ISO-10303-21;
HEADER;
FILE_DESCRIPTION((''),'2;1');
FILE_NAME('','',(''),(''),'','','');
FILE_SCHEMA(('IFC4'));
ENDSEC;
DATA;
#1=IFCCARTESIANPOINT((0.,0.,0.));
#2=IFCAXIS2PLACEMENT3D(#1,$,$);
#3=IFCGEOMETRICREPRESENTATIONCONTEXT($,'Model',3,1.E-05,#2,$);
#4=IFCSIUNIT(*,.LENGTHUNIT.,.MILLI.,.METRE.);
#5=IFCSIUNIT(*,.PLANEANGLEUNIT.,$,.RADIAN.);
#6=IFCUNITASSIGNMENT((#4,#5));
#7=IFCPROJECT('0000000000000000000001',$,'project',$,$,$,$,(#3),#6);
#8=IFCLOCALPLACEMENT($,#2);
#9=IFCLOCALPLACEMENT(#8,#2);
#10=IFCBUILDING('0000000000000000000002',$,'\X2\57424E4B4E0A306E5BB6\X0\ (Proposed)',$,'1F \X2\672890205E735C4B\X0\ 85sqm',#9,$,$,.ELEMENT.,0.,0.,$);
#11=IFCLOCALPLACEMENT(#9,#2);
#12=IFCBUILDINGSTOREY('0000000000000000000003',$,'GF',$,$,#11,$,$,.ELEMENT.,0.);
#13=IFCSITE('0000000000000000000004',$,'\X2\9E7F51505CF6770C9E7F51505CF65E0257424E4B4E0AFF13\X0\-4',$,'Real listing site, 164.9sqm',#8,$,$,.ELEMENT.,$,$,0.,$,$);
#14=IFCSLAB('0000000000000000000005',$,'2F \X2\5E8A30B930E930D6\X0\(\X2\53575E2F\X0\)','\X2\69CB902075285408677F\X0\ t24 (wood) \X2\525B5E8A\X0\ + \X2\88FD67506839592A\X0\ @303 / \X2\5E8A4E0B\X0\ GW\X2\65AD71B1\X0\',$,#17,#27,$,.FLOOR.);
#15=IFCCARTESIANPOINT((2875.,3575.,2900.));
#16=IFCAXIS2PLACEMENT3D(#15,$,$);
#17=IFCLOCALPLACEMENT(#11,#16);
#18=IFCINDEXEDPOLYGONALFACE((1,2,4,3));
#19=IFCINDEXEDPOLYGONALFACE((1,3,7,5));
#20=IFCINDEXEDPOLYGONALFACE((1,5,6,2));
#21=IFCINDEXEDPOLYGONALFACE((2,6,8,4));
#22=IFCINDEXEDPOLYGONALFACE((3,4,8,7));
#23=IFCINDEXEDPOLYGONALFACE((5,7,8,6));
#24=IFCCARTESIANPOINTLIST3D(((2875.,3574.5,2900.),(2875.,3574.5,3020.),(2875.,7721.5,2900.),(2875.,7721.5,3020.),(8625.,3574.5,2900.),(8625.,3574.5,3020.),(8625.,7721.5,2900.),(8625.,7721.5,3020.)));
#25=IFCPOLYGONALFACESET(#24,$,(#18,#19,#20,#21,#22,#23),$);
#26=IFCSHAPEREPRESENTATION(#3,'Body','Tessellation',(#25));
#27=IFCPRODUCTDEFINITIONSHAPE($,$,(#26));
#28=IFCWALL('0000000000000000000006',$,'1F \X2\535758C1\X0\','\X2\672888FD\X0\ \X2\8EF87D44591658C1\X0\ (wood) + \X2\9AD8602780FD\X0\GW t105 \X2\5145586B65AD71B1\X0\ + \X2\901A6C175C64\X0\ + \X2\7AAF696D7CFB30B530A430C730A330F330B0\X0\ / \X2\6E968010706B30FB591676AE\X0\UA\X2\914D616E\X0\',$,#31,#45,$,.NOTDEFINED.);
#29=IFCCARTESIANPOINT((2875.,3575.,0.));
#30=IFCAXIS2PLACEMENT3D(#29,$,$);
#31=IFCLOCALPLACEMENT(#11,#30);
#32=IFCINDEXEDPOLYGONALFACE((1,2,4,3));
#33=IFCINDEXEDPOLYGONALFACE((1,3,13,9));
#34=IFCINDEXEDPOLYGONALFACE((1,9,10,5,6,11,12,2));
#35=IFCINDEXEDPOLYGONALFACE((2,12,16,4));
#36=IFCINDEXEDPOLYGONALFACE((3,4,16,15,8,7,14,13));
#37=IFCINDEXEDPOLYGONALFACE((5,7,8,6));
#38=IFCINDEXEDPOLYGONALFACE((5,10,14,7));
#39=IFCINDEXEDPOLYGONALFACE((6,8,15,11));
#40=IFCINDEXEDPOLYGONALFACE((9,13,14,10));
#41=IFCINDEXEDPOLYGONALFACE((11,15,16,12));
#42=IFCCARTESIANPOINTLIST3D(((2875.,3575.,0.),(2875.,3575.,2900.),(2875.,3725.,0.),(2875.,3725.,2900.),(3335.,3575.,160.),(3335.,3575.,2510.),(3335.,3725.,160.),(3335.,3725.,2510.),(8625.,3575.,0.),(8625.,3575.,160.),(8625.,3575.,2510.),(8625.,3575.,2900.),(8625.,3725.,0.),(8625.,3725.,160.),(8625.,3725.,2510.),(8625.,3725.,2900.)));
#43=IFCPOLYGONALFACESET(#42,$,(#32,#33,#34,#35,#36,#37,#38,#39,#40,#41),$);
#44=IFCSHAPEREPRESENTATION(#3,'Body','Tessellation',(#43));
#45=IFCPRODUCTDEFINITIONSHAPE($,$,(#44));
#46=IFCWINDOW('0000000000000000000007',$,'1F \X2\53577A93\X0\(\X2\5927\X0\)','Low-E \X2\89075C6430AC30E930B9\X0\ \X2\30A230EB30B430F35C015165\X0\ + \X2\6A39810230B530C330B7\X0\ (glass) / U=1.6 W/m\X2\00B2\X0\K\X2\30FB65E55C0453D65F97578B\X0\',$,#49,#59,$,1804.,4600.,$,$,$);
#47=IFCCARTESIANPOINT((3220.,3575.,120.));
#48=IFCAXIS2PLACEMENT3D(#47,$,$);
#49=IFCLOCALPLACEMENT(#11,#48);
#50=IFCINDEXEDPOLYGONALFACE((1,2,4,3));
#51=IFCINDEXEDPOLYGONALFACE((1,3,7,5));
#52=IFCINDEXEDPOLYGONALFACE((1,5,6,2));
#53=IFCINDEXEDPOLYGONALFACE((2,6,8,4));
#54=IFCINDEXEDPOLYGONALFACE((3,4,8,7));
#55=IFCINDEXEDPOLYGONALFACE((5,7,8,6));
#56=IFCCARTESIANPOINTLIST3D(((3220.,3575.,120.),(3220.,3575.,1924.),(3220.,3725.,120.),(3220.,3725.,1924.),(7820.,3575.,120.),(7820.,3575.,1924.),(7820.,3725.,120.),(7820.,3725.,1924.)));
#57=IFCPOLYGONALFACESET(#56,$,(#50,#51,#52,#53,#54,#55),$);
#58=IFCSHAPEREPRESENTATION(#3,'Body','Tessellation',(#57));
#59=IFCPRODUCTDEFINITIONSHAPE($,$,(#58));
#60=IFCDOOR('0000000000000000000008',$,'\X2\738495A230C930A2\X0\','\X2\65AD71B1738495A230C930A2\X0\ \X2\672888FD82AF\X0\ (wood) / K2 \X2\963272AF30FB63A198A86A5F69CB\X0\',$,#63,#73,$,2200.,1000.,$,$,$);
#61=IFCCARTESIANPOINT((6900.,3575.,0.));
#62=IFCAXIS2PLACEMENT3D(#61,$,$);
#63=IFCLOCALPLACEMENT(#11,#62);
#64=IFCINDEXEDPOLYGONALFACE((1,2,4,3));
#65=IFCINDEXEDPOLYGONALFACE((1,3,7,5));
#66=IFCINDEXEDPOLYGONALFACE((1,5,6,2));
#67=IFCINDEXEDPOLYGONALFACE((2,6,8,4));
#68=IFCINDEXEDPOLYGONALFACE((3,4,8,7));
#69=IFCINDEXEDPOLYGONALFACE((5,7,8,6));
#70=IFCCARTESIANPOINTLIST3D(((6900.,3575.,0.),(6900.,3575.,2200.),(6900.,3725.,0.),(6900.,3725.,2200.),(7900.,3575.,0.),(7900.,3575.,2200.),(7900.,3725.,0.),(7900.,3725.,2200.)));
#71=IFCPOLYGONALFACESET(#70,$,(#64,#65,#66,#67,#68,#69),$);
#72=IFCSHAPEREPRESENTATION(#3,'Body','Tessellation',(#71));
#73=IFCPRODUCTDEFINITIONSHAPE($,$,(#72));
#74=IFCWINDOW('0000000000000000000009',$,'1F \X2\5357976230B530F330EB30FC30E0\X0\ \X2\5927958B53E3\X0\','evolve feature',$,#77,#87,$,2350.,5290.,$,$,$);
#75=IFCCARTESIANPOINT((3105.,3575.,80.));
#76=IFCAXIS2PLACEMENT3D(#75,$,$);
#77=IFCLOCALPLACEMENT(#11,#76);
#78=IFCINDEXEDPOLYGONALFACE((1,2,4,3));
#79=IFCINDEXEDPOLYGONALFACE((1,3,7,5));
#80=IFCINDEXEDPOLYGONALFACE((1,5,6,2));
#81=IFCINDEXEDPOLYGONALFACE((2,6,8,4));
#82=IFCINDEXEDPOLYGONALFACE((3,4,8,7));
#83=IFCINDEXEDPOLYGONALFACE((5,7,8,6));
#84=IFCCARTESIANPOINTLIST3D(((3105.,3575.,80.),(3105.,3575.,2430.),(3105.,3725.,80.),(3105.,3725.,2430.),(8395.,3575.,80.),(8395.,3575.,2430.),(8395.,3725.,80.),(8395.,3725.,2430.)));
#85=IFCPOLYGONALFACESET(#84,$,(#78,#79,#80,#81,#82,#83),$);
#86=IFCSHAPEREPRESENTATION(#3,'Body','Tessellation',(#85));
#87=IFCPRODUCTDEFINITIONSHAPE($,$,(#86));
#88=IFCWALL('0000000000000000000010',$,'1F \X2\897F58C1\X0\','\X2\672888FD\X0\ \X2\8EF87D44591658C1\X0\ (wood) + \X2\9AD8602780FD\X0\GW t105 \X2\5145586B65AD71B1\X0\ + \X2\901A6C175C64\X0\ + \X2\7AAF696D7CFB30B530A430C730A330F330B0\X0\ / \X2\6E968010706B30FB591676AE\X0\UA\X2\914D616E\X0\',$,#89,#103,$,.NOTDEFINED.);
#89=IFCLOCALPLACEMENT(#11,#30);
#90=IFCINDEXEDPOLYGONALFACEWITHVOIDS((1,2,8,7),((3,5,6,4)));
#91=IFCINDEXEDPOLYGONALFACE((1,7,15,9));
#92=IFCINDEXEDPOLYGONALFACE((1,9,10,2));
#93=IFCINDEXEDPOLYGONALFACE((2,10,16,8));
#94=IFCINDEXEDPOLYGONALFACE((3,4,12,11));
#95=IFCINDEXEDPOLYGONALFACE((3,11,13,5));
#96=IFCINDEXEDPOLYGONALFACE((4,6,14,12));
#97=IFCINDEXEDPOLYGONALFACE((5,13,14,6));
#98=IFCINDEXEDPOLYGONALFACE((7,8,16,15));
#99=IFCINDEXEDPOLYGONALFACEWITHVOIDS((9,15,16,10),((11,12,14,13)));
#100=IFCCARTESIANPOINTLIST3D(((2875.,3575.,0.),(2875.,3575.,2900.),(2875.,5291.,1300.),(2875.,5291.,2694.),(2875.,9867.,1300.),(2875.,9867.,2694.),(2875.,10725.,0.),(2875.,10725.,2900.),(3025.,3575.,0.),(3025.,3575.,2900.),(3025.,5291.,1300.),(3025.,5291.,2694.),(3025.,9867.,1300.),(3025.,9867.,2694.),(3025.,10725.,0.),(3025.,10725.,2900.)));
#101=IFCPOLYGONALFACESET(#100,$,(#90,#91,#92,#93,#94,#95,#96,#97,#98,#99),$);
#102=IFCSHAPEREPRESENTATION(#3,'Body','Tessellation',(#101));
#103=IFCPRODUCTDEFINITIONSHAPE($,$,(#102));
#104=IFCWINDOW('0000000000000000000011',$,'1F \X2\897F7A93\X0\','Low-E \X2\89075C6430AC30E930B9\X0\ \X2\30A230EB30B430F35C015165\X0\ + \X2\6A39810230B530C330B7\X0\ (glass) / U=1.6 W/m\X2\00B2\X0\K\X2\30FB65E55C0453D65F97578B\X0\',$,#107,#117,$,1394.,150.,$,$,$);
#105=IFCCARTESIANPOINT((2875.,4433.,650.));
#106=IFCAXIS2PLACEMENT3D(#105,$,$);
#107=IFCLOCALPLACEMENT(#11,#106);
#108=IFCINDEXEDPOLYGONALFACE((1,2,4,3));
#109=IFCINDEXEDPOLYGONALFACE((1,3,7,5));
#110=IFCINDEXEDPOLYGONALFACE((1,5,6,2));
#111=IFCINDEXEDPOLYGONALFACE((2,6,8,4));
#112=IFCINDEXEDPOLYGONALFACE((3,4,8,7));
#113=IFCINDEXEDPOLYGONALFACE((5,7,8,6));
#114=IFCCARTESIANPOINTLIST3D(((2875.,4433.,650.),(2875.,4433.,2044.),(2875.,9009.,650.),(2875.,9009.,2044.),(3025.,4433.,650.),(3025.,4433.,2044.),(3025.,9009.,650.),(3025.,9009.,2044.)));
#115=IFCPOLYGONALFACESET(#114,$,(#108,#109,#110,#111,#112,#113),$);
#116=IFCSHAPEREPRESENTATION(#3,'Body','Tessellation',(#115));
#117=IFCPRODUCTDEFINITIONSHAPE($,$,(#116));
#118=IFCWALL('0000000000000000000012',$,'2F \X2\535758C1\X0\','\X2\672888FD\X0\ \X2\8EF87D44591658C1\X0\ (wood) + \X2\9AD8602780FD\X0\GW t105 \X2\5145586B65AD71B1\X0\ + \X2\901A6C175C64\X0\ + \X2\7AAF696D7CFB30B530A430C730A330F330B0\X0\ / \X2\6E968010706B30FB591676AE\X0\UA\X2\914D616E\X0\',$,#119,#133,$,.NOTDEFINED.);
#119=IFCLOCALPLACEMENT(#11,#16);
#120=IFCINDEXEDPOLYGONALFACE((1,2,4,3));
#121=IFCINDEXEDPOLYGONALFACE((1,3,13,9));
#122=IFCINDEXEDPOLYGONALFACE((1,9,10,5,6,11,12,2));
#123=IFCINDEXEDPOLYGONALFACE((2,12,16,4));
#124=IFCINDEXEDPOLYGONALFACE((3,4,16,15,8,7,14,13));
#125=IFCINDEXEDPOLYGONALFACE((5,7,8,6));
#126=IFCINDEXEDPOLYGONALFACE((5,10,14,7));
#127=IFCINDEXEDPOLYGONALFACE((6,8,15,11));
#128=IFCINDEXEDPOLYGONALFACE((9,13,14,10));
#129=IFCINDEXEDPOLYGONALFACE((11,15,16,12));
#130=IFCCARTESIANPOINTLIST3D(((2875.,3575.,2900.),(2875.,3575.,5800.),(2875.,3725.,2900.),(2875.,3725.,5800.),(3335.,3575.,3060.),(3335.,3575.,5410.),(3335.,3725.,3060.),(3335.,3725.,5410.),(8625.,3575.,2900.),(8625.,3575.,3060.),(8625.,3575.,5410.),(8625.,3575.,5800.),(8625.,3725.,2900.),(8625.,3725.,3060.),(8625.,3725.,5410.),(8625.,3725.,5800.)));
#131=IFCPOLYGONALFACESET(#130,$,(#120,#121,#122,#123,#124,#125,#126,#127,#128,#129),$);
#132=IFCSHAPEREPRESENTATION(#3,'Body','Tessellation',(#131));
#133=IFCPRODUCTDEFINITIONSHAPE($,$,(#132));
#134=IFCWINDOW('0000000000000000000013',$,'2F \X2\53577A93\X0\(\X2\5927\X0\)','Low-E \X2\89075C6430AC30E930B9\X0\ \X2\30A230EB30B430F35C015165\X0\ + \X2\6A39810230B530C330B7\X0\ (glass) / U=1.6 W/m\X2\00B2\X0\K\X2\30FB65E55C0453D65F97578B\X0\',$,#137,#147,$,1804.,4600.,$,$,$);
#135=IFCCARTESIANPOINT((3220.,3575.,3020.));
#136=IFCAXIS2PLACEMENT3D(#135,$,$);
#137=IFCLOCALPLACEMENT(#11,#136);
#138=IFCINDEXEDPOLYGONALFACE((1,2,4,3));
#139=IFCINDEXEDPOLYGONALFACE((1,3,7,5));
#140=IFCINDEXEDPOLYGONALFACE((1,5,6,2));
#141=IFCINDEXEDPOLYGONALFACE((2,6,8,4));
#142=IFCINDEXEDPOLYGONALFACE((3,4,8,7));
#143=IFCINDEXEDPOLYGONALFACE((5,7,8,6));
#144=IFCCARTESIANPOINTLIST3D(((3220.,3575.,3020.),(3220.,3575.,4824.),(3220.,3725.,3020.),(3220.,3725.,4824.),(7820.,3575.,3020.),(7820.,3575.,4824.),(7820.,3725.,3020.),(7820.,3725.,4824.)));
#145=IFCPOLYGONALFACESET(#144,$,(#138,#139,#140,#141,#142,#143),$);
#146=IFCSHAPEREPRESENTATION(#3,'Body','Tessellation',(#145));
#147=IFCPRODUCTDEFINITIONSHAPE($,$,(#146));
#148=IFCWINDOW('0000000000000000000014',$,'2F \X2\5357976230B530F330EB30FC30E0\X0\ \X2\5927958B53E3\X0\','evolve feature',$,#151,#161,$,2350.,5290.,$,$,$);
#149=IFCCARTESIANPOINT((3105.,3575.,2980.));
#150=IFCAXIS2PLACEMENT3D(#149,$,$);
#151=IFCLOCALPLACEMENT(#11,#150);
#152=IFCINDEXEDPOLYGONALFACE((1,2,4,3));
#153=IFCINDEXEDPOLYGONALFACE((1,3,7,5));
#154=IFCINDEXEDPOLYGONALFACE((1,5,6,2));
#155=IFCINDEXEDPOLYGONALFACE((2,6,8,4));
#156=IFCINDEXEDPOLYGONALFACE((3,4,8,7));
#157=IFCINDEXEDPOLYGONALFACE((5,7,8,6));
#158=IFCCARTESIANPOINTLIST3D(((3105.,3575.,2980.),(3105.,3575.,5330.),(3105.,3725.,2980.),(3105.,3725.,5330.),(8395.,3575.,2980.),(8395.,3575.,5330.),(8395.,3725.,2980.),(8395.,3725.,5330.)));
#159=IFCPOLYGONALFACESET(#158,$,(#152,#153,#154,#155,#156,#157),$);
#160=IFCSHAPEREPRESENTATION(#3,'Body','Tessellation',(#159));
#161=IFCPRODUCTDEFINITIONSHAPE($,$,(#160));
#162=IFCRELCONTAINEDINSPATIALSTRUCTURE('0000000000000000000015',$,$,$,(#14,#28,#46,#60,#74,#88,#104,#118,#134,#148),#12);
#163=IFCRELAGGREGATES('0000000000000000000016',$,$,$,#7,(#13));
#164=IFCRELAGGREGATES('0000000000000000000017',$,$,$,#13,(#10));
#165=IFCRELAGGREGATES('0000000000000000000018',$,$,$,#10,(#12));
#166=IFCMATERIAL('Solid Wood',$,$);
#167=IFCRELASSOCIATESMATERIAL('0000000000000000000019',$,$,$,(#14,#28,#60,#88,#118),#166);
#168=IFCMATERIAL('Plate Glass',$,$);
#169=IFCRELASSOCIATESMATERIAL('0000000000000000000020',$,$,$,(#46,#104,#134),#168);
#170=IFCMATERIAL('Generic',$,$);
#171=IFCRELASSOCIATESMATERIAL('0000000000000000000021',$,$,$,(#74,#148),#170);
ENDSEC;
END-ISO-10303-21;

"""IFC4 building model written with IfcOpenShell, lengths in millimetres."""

from ifc_helpers import new_model, si_unit, frame, frame_2d, origin, place, context, project, spatial, rectangle, extrude, material, element, fill, save


model = new_model("IFC4")

# Units and contexts
model_context = context("Model", 3, precision=1e-05, world=origin())
ifc_project = project(units=[si_unit("LENGTHUNIT", "METRE", prefix="MILLI"), si_unit("PLANEANGLEUNIT", "RADIAN")], contexts=[model_context])

# Site, building, storey
site_placement = place(None, origin())
site = spatial("IfcSite", under=ifc_project, at=site_placement, Name="鹿児島県鹿児島市坂之上３-4", ObjectType="Real listing site, 164.9sqm", CompositionType="ELEMENT", RefElevation=0.0)
building_placement = place(site_placement, origin())
building = spatial("IfcBuilding", under=site, at=building_placement, Name="坂之上の家 (Proposed)", ObjectType="1F 木造平屋 85sqm", CompositionType="ELEMENT", ElevationOfRefHeight=0.0, ElevationOfTerrain=0.0)
storey_placement = place(building_placement, origin())
storey = spatial("IfcBuildingStorey", under=building, at=storey_placement, Name="GF", CompositionType="ELEMENT", Elevation=0.0)

# Slab
ifc_material_1 = material(Name="Solid Wood")
slab_1_placement = place(storey_placement, frame((2875.0, 3575.0, 2900.0)))
element("IfcSlab", 1, at=slab_1_placement, inside=storey, material=ifc_material_1, Name="2F 床スラブ(南帯)", Description="構造用合板 t24 (wood) 剛床 + 製材根太 @303 / 床下 GW断熱", PredefinedType="FLOOR", context=model_context, shape_type="SweptSolid", body=[
    extrude(rectangle(XDim=5750.0, YDim=4147.0, at=frame_2d((2875.0, 2073.0))), frame((2875.0, 3575.0, 2900.0)), (0.0, 0.0, 1.0), 120.0),
])
ifc_material_2 = material(Name="Generic")

# Wall, openings, windows, door
wall_1_placement = place(storey_placement, frame((2875.0, 3575.0, 0.0)))
wall_1 = element("IfcWall", 2, at=wall_1_placement, inside=storey, material=ifc_material_1, Name="1F 南壁", Description="木製 軸組外壁 (wood) + 高性能GW t105 充填断熱 + 通気層 + 窯業系サイディング / 準耐火・外皮UA配慮", PredefinedType="NOTDEFINED", context=model_context, shape_type="SweptSolid", body=[
    extrude(rectangle(XDim=5750.0, YDim=150.0, at=frame_2d((2875.0, 75.0))), frame((2875.0, 3575.0, 0.0)), (0.0, 0.0, 1.0), 2900.0),
])
opening_1_placement = place(storey_placement, frame((3220.0, 3575.0, 120.0)))
opening_1 = element("IfcOpeningElement", 3, at=opening_1_placement, cuts=wall_1, PredefinedType="NOTDEFINED", context=model_context, shape_type="SweptSolid", body=[
    extrude(rectangle(XDim=4600.0, YDim=150.0, at=frame_2d((2300.0, 75.0))), frame((3220.0, 3575.0, 120.0)), (0.0, 0.0, 1.0), 1804.0),
])
opening_2_placement = place(storey_placement, frame((6900.0, 3575.0, 0.0)))
opening_2 = element("IfcOpeningElement", 4, at=opening_2_placement, cuts=wall_1, PredefinedType="NOTDEFINED", context=model_context, shape_type="SweptSolid", body=[
    extrude(rectangle(XDim=1000.0, YDim=150.0, at=frame_2d((500.0, 75.0))), frame((6900.0, 3575.0, 0.0)), (0.0, 0.0, 1.0), 2200.0),
])
opening_3_placement = place(storey_placement, frame((3105.0, 3575.0, 80.0)))
opening_3 = element("IfcOpeningElement", 5, at=opening_3_placement, cuts=wall_1, PredefinedType="NOTDEFINED", context=model_context, shape_type="SweptSolid", body=[
    extrude(rectangle(XDim=5290.0, YDim=150.0, at=frame_2d((2645.0, 75.0))), frame((3105.0, 3575.0, 80.0)), (0.0, 0.0, 1.0), 2350.0),
])
ifc_material_3 = material(Name="Plate Glass")
window_1_placement = place(storey_placement, frame((3220.0, 3575.0, 120.0)))
window_1 = element("IfcWindow", 6, at=window_1_placement, inside=storey, material=ifc_material_3, Name="1F 南窓(大)", Description="Low-E 複層ガラス アルゴン封入 + 樹脂サッシ (glass) / U=1.6 W/m²K・日射取得型", OverallHeight=1804.0, OverallWidth=4600.0, context=model_context, shape_type="SweptSolid", body=[
    extrude(rectangle(XDim=4600.0, YDim=150.0, at=frame_2d((2300.0, 75.0))), frame((3220.0, 3575.0, 120.0)), (0.0, 0.0, 1.0), 1804.0),
])
fill(opening_1, window_1)
door_placement = place(storey_placement, frame((6900.0, 3575.0, 0.0)))
door = element("IfcDoor", 7, at=door_placement, inside=storey, material=ifc_material_1, Name="玄関ドア", Description="断熱玄関ドア 木製芯 (wood) / K2 防犯・採風機構", OverallHeight=2200.0, OverallWidth=1000.0, context=model_context, shape_type="SweptSolid", body=[
    extrude(rectangle(XDim=1000.0, YDim=150.0, at=frame_2d((500.0, 75.0))), frame((6900.0, 3575.0, 0.0)), (0.0, 0.0, 1.0), 2200.0),
])
fill(opening_2, door)
window_2_placement = place(storey_placement, frame((3105.0, 3575.0, 80.0)))
window_2 = element("IfcWindow", 8, at=window_2_placement, inside=storey, material=ifc_material_2, Name="1F 南面サンルーム 大開口", Description="evolve feature", OverallHeight=2350.0, OverallWidth=5290.0, context=model_context, shape_type="SweptSolid", body=[
    extrude(rectangle(XDim=5290.0, YDim=150.0, at=frame_2d((2645.0, 75.0))), frame((3105.0, 3575.0, 80.0)), (0.0, 0.0, 1.0), 2350.0),
])
fill(opening_3, window_2)

# Wall, opening, window
wall_2_placement = place(storey_placement, frame((2875.0, 3575.0, 0.0)))
wall_2 = element("IfcWall", 9, at=wall_2_placement, inside=storey, material=ifc_material_1, Name="1F 西壁", Description="木製 軸組外壁 (wood) + 高性能GW t105 充填断熱 + 通気層 + 窯業系サイディング / 準耐火・外皮UA配慮", PredefinedType="NOTDEFINED", context=model_context, shape_type="SweptSolid", body=[
    extrude(rectangle(XDim=150.0, YDim=7150.0, at=frame_2d((75.0, 3575.0))), frame((2875.0, 3575.0, 0.0)), (0.0, 0.0, 1.0), 2900.0),
])
opening_4_placement = place(storey_placement, frame((2875.0, 4433.0, 650.0)))
opening_4 = element("IfcOpeningElement", 10, at=opening_4_placement, cuts=wall_2, PredefinedType="NOTDEFINED", context=model_context, shape_type="SweptSolid", body=[
    extrude(rectangle(XDim=150.0, YDim=4576.0, at=frame_2d((75.0, 2288.0))), frame((2875.0, 4433.0, 650.0)), (0.0, 0.0, 1.0), 1394.0),
])
window_3_placement = place(storey_placement, frame((2875.0, 4433.0, 650.0)))
window_3 = element("IfcWindow", 11, at=window_3_placement, inside=storey, material=ifc_material_3, Name="1F 西窓", Description="Low-E 複層ガラス アルゴン封入 + 樹脂サッシ (glass) / U=1.6 W/m²K・日射取得型", OverallHeight=1394.0, OverallWidth=150.0, context=model_context, shape_type="SweptSolid", body=[
    extrude(rectangle(XDim=150.0, YDim=4576.0, at=frame_2d((75.0, 2288.0))), frame((2875.0, 4433.0, 650.0)), (0.0, 0.0, 1.0), 1394.0),
])
fill(opening_4, window_3)

# Wall, openings, windows
wall_3_placement = place(storey_placement, frame((2875.0, 3575.0, 2900.0)))
wall_3 = element("IfcWall", 12, at=wall_3_placement, inside=storey, material=ifc_material_1, Name="2F 南壁", Description="木製 軸組外壁 (wood) + 高性能GW t105 充填断熱 + 通気層 + 窯業系サイディング / 準耐火・外皮UA配慮", PredefinedType="NOTDEFINED", context=model_context, shape_type="SweptSolid", body=[
    extrude(rectangle(XDim=5750.0, YDim=150.0, at=frame_2d((2875.0, 75.0))), frame((2875.0, 3575.0, 2900.0)), (0.0, 0.0, 1.0), 2900.0),
])
opening_5_placement = place(storey_placement, frame((3220.0, 3575.0, 3020.0)))
opening_5 = element("IfcOpeningElement", 13, at=opening_5_placement, cuts=wall_3, PredefinedType="NOTDEFINED", context=model_context, shape_type="SweptSolid", body=[
    extrude(rectangle(XDim=4600.0, YDim=150.0, at=frame_2d((2300.0, 75.0))), frame((3220.0, 3575.0, 3020.0)), (0.0, 0.0, 1.0), 1804.0),
])
opening_6_placement = place(storey_placement, frame((3105.0, 3575.0, 2980.0)))
opening_6 = element("IfcOpeningElement", 14, at=opening_6_placement, cuts=wall_3, PredefinedType="NOTDEFINED", context=model_context, shape_type="SweptSolid", body=[
    extrude(rectangle(XDim=5290.0, YDim=150.0, at=frame_2d((2645.0, 75.0))), frame((3105.0, 3575.0, 2980.0)), (0.0, 0.0, 1.0), 2350.0),
])
window_4_placement = place(storey_placement, frame((3220.0, 3575.0, 3020.0)))
window_4 = element("IfcWindow", 15, at=window_4_placement, inside=storey, material=ifc_material_3, Name="2F 南窓(大)", Description="Low-E 複層ガラス アルゴン封入 + 樹脂サッシ (glass) / U=1.6 W/m²K・日射取得型", OverallHeight=1804.0, OverallWidth=4600.0, context=model_context, shape_type="SweptSolid", body=[
    extrude(rectangle(XDim=4600.0, YDim=150.0, at=frame_2d((2300.0, 75.0))), frame((3220.0, 3575.0, 3020.0)), (0.0, 0.0, 1.0), 1804.0),
])
fill(opening_5, window_4)
window_5_placement = place(storey_placement, frame((3105.0, 3575.0, 2980.0)))
window_5 = element("IfcWindow", 16, at=window_5_placement, inside=storey, material=ifc_material_2, Name="2F 南面サンルーム 大開口", Description="evolve feature", OverallHeight=2350.0, OverallWidth=5290.0, context=model_context, shape_type="SweptSolid", body=[
    extrude(rectangle(XDim=5290.0, YDim=150.0, at=frame_2d((2645.0, 75.0))), frame((3105.0, 3575.0, 2980.0)), (0.0, 0.0, 1.0), 2350.0),
])
fill(opening_6, window_5)

save(model, "model.ifc")
